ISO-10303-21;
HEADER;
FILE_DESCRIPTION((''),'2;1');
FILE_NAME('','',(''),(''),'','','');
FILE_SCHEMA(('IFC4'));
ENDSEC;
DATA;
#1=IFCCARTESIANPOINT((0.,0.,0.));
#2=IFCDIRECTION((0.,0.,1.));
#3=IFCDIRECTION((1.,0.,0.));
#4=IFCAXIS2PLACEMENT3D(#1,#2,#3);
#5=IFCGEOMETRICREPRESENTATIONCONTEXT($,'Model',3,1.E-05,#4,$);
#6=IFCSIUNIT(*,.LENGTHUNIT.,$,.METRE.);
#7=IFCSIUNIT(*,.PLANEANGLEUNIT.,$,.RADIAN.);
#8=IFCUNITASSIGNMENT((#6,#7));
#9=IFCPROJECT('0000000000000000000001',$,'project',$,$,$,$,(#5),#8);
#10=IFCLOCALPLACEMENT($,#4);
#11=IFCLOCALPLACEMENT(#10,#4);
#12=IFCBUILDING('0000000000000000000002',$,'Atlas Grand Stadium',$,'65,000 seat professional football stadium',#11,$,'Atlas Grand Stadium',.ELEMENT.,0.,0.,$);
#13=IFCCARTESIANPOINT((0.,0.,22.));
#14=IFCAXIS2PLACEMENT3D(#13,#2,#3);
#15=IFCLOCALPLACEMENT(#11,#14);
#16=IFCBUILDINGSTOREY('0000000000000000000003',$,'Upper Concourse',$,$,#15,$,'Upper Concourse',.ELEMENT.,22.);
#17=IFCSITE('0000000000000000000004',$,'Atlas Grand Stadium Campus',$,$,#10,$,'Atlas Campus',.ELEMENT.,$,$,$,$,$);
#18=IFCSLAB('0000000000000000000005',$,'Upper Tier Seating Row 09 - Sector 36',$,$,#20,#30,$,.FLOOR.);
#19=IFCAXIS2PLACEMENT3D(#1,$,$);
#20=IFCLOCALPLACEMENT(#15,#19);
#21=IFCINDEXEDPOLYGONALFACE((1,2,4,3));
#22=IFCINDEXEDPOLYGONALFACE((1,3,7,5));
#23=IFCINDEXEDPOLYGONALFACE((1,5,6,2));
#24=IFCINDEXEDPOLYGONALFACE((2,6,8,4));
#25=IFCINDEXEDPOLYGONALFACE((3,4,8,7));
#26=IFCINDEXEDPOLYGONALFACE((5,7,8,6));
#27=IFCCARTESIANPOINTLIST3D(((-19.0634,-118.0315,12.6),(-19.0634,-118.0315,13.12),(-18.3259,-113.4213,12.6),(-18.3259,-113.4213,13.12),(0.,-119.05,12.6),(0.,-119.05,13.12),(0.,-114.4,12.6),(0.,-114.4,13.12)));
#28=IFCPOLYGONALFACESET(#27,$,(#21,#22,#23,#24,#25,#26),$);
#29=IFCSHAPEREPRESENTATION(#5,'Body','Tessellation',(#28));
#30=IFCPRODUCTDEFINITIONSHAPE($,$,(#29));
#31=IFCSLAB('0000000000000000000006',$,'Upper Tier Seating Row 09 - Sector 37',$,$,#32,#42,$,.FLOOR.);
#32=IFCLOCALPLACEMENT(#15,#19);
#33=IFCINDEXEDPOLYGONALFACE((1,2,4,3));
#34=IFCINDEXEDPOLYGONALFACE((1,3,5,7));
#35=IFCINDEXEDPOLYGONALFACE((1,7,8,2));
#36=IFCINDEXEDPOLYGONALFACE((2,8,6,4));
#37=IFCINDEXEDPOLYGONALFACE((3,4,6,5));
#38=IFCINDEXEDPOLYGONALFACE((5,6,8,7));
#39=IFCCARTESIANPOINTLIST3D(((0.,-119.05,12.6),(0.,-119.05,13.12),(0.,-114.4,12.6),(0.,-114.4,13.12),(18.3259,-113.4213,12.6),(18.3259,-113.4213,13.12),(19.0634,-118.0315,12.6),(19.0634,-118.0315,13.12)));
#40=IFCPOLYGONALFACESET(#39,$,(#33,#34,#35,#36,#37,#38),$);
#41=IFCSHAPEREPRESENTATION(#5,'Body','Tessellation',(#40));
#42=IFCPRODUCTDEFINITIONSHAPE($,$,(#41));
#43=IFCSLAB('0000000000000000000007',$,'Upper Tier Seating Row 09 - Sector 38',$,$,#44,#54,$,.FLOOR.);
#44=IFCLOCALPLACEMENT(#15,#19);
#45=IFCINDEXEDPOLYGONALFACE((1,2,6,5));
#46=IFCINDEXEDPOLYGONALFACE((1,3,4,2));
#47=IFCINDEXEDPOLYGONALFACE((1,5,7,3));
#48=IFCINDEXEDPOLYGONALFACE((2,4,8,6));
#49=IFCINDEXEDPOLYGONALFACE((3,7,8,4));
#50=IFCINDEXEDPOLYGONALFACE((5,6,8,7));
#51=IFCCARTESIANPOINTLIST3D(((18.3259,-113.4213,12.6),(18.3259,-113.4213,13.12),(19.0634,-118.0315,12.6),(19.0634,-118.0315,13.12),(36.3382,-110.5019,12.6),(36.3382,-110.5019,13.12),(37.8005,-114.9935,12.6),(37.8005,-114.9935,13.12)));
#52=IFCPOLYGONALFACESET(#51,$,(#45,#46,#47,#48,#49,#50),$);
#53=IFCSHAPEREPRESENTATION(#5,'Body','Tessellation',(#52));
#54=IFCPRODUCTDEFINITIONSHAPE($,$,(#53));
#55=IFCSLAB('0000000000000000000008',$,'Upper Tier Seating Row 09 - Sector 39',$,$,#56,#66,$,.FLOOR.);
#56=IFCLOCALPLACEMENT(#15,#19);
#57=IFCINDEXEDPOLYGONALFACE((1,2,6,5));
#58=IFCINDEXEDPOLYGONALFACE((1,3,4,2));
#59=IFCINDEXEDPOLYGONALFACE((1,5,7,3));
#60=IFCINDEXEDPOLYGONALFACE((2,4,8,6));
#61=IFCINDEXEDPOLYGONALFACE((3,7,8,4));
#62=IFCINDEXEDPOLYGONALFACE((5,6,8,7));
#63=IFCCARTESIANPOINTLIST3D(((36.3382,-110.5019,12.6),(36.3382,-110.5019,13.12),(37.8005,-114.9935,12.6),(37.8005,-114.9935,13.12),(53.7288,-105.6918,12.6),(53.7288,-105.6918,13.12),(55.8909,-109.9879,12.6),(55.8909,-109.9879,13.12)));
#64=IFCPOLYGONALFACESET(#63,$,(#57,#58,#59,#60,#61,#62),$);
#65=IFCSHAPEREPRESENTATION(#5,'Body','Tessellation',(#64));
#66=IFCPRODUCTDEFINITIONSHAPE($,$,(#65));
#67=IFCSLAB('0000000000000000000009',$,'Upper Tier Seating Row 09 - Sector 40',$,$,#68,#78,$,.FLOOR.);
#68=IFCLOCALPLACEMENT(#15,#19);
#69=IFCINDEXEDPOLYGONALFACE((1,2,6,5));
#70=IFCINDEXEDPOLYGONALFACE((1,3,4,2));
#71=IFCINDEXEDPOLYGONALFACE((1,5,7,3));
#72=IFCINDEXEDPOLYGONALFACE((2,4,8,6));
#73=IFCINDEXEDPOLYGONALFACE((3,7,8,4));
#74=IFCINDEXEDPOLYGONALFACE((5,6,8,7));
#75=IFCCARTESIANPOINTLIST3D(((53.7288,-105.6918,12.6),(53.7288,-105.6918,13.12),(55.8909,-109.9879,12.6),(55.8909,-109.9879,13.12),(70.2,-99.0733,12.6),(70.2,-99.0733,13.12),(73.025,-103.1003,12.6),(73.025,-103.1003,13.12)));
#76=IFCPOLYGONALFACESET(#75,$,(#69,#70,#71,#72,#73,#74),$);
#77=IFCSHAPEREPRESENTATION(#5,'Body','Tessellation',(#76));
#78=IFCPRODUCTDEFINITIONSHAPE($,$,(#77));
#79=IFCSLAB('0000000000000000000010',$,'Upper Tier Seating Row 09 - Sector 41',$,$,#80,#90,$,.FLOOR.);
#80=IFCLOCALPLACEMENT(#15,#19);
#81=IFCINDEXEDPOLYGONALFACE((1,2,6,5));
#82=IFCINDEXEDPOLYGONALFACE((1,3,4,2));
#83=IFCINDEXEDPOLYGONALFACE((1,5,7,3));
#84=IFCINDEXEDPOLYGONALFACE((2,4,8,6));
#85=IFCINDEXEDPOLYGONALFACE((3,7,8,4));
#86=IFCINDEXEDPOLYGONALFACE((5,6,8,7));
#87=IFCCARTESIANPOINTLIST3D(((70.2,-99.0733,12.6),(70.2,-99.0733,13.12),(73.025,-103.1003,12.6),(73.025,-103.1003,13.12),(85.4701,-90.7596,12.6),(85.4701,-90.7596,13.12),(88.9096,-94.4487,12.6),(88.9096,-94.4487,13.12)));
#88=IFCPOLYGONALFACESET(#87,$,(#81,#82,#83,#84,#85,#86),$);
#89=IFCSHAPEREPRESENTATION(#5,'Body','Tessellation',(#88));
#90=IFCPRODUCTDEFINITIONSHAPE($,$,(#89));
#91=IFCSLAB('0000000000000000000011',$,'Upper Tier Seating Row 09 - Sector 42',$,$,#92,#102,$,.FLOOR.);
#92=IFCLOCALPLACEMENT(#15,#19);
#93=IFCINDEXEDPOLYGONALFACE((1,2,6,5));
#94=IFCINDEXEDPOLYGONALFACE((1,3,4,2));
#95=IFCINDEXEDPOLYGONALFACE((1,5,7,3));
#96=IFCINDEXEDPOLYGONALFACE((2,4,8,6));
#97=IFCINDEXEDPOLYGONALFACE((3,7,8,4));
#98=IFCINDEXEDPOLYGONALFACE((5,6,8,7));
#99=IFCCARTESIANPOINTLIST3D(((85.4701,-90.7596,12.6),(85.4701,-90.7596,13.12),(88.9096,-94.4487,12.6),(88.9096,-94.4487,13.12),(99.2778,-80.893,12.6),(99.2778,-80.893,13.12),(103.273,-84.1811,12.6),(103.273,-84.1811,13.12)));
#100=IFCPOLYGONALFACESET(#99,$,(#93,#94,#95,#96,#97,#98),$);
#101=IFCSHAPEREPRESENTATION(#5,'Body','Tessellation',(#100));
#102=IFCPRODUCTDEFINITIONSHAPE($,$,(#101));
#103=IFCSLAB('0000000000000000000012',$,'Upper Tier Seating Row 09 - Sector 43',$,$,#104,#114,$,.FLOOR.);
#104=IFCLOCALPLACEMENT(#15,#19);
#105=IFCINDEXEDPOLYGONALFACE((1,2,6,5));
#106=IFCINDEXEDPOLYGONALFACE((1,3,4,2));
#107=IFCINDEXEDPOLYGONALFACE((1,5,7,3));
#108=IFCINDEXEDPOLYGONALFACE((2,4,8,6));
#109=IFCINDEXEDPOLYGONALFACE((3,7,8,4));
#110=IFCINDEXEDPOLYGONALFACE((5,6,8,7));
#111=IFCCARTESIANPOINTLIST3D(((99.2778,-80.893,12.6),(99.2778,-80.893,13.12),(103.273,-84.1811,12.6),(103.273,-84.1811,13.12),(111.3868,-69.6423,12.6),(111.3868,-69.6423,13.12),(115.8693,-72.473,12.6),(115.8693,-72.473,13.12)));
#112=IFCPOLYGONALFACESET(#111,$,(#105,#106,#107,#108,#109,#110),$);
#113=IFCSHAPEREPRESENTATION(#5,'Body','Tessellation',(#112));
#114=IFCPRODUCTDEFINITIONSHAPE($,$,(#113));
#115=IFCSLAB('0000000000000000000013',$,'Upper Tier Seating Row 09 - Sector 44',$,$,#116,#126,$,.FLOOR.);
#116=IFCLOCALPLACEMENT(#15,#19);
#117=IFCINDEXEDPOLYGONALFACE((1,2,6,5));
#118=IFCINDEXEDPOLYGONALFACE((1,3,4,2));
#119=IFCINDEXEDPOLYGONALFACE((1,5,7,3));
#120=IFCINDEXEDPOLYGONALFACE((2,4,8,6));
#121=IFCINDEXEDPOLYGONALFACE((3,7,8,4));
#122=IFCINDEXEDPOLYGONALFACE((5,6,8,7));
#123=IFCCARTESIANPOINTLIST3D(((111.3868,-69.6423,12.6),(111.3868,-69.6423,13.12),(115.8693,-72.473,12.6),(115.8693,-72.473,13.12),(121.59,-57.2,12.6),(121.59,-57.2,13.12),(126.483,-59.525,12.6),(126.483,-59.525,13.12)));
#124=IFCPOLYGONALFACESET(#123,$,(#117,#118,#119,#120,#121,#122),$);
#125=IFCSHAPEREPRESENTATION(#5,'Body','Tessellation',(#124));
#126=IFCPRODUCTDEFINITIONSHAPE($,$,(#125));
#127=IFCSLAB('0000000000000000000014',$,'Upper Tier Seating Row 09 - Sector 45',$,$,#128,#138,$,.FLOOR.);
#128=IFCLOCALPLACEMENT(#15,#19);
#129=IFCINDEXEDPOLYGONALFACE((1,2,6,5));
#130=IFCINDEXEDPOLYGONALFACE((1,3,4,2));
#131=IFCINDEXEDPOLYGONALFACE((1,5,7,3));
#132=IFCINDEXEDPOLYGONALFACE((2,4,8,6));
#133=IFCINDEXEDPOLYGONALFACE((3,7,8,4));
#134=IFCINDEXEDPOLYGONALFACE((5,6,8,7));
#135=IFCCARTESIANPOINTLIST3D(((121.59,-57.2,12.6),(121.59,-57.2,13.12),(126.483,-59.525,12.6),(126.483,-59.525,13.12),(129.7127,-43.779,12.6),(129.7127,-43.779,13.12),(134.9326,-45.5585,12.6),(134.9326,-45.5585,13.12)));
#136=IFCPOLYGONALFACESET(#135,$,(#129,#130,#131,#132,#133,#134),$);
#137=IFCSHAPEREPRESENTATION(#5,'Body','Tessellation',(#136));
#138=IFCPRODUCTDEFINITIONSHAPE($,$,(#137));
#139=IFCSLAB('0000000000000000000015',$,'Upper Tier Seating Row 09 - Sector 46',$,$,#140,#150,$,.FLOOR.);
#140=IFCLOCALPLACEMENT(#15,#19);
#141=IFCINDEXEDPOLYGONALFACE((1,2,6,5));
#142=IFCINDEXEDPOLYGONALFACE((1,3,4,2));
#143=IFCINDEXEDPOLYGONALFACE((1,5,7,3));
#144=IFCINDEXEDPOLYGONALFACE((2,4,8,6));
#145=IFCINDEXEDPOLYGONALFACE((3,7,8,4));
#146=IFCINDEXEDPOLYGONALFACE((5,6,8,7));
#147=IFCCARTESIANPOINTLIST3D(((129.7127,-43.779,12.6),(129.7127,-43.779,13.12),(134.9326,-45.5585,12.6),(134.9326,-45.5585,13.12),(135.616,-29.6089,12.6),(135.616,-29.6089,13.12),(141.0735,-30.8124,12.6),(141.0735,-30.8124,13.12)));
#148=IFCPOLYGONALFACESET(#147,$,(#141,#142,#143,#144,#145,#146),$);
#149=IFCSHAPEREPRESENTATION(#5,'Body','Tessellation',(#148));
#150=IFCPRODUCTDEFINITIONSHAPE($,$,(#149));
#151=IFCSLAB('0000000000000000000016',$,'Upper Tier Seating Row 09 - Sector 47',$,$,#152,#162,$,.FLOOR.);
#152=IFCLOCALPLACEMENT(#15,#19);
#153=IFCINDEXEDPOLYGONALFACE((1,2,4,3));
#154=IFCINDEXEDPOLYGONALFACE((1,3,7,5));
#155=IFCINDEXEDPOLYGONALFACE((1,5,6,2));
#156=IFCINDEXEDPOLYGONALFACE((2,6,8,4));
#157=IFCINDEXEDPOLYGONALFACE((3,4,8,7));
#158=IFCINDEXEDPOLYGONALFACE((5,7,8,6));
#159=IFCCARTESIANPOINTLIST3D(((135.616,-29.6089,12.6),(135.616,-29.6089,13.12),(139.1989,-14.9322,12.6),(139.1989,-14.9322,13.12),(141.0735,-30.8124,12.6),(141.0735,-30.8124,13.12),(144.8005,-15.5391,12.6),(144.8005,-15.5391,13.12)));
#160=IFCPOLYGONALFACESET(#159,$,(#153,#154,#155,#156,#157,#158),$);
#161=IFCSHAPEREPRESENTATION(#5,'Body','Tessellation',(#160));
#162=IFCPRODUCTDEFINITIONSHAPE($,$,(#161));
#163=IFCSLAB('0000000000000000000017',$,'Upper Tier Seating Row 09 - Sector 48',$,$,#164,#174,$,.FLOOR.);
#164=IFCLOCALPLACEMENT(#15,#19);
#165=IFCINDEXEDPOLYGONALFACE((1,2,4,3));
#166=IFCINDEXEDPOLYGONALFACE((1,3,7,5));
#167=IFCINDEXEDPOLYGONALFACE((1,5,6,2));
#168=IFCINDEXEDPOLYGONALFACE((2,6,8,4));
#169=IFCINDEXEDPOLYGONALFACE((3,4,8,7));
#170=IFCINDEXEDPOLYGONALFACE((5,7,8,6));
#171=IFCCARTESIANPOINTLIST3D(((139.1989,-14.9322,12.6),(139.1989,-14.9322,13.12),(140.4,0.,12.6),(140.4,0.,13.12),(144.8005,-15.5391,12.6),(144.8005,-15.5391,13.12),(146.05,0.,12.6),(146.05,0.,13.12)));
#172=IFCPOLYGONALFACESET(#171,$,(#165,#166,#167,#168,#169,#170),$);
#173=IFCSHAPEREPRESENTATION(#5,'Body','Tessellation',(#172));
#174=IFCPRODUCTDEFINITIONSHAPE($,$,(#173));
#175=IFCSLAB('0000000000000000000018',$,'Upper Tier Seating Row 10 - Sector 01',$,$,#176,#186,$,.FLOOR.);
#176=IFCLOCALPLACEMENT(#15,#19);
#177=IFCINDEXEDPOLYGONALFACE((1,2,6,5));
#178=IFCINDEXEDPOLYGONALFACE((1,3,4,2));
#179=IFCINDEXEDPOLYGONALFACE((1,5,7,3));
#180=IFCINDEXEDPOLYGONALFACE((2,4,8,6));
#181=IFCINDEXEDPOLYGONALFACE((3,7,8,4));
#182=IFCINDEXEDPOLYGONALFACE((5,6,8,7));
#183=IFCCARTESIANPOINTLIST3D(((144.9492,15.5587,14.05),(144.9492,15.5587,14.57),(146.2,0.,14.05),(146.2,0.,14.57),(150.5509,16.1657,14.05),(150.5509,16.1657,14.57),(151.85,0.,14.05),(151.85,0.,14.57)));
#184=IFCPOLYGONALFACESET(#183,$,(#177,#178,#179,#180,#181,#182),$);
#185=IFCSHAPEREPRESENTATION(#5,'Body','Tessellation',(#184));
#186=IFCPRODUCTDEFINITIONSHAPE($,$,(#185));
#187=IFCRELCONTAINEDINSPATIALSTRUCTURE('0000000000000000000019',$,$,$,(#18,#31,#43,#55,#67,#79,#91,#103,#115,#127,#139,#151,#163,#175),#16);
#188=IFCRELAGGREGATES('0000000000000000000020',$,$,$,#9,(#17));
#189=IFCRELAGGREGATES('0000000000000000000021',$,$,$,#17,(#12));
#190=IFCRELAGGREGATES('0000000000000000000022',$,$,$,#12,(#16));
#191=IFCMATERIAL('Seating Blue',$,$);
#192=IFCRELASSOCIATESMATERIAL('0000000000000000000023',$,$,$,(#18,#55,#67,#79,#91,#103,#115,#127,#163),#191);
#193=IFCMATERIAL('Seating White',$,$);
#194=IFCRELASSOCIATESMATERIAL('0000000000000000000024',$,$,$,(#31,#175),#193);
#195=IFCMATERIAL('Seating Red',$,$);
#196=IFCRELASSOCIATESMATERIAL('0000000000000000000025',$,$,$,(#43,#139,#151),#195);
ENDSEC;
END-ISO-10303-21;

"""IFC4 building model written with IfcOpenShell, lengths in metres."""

from ifc_helpers import new_model, si_unit, frame, origin_with_axes, place, context, project, spatial, polyline, outline, extrude, material, element, save


model = new_model("IFC4")

# Units and contexts
model_context = context("Model", 3, precision=1e-05, world=origin_with_axes())
ifc_project = project(units=[si_unit("LENGTHUNIT", "METRE"), si_unit("PLANEANGLEUNIT", "RADIAN")], contexts=[model_context])

# Site, building, storey
site_placement = place(None, origin_with_axes())
site = spatial("IfcSite", under=ifc_project, at=site_placement, Name="Atlas Grand Stadium Campus", LongName="Atlas Campus", CompositionType="ELEMENT")
building_placement = place(site_placement, origin_with_axes())
building = spatial("IfcBuilding", under=site, at=building_placement, Name="Atlas Grand Stadium", ObjectType="65,000 seat professional football stadium", LongName="Atlas Grand Stadium", CompositionType="ELEMENT", ElevationOfRefHeight=0.0, ElevationOfTerrain=0.0)
storey_placement = place(building_placement, frame((0.0, 0.0, 22.0), z_axis=(0.0, 0.0, 1.0), x_axis=(1.0, 0.0, 0.0)))
storey = spatial("IfcBuildingStorey", under=building, at=storey_placement, Name="Upper Concourse", LongName="Upper Concourse", CompositionType="ELEMENT", Elevation=22.0)

# Slabs
ifc_material_1 = material(Name="Seating Blue")
slab_1_placement = place(storey_placement, frame((0.0, 0.0, 12.6), z_axis=(0.0, 0.0, 1.0), x_axis=(1.0, 0.0, 0.0)))
element("IfcSlab", 1, at=slab_1_placement, inside=storey, material=ifc_material_1, Name="Upper Tier Seating Row 09 - Sector 36", PredefinedType="FLOOR", context=model_context, shape_type="SweptSolid", body=[
    extrude(outline(polyline([(-19.0633, -118.0315), (0.0, -119.05), (0.0, -114.4), (-18.3259, -113.4213), (-19.0633, -118.0315)])), origin_with_axes(), (0.0, 0.0, 1.0), 0.52),
])
ifc_material_2 = material(Name="Seating White")
slab_2_placement = place(storey_placement, frame((0.0, 0.0, 12.6), z_axis=(0.0, 0.0, 1.0), x_axis=(1.0, 0.0, 0.0)))
element("IfcSlab", 2, at=slab_2_placement, inside=storey, material=ifc_material_2, Name="Upper Tier Seating Row 09 - Sector 37", PredefinedType="FLOOR", context=model_context, shape_type="SweptSolid", body=[
    extrude(outline(polyline([(0.0, -119.05), (19.0633, -118.0315), (18.3259, -113.4213), (0.0, -114.4), (0.0, -119.05)])), origin_with_axes(), (0.0, 0.0, 1.0), 0.52),
])
ifc_material_3 = material(Name="Seating Red")
slab_3_placement = place(storey_placement, frame((0.0, 0.0, 12.6), z_axis=(0.0, 0.0, 1.0), x_axis=(1.0, 0.0, 0.0)))
element("IfcSlab", 3, at=slab_3_placement, inside=storey, material=ifc_material_3, Name="Upper Tier Seating Row 09 - Sector 38", PredefinedType="FLOOR", context=model_context, shape_type="SweptSolid", body=[
    extrude(outline(polyline([(19.0633, -118.0315), (37.8005, -114.9935), (36.3382, -110.5019), (18.3259, -113.4213), (19.0633, -118.0315)])), origin_with_axes(), (0.0, 0.0, 1.0), 0.52),
])
slab_4_placement = place(storey_placement, frame((0.0, 0.0, 12.6), z_axis=(0.0, 0.0, 1.0), x_axis=(1.0, 0.0, 0.0)))
element("IfcSlab", 4, at=slab_4_placement, inside=storey, material=ifc_material_1, Name="Upper Tier Seating Row 09 - Sector 39", PredefinedType="FLOOR", context=model_context, shape_type="SweptSolid", body=[
    extrude(outline(polyline([(37.8005, -114.9935), (55.8909, -109.9879), (53.7287, -105.6918), (36.3382, -110.5019), (37.8005, -114.9935)])), origin_with_axes(), (0.0, 0.0, 1.0), 0.52),
])
slab_5_placement = place(storey_placement, frame((0.0, 0.0, 12.6), z_axis=(0.0, 0.0, 1.0), x_axis=(1.0, 0.0, 0.0)))
element("IfcSlab", 5, at=slab_5_placement, inside=storey, material=ifc_material_1, Name="Upper Tier Seating Row 09 - Sector 40", PredefinedType="FLOOR", context=model_context, shape_type="SweptSolid", body=[
    extrude(outline(polyline([(55.8909, -109.9879), (73.025, -103.1003), (70.2, -99.0733), (53.7287, -105.6918), (55.8909, -109.9879)])), origin_with_axes(), (0.0, 0.0, 1.0), 0.52),
])
slab_6_placement = place(storey_placement, frame((0.0, 0.0, 12.6), z_axis=(0.0, 0.0, 1.0), x_axis=(1.0, 0.0, 0.0)))
element("IfcSlab", 6, at=slab_6_placement, inside=storey, material=ifc_material_1, Name="Upper Tier Seating Row 09 - Sector 41", PredefinedType="FLOOR", context=model_context, shape_type="SweptSolid", body=[
    extrude(outline(polyline([(73.025, -103.1003), (88.9096, -94.4487), (85.4701, -90.7596), (70.2, -99.0733), (73.025, -103.1003)])), origin_with_axes(), (0.0, 0.0, 1.0), 0.52),
])
slab_7_placement = place(storey_placement, frame((0.0, 0.0, 12.6), z_axis=(0.0, 0.0, 1.0), x_axis=(1.0, 0.0, 0.0)))
element("IfcSlab", 7, at=slab_7_placement, inside=storey, material=ifc_material_1, Name="Upper Tier Seating Row 09 - Sector 42", PredefinedType="FLOOR", context=model_context, shape_type="SweptSolid", body=[
    extrude(outline(polyline([(88.9096, -94.4487), (103.2729, -84.1811), (99.2778, -80.893), (85.4701, -90.7596), (88.9096, -94.4487)])), origin_with_axes(), (0.0, 0.0, 1.0), 0.52),
])
slab_8_placement = place(storey_placement, frame((0.0, 0.0, 12.6), z_axis=(0.0, 0.0, 1.0), x_axis=(1.0, 0.0, 0.0)))
element("IfcSlab", 8, at=slab_8_placement, inside=storey, material=ifc_material_1, Name="Upper Tier Seating Row 09 - Sector 43", PredefinedType="FLOOR", context=model_context, shape_type="SweptSolid", body=[
    extrude(outline(polyline([(103.2729, -84.1811), (115.8693, -72.4731), (111.3868, -69.6423), (99.2778, -80.893), (103.2729, -84.1811)])), origin_with_axes(), (0.0, 0.0, 1.0), 0.52),
])
slab_9_placement = place(storey_placement, frame((0.0, 0.0, 12.6), z_axis=(0.0, 0.0, 1.0), x_axis=(1.0, 0.0, 0.0)))
element("IfcSlab", 9, at=slab_9_placement, inside=storey, material=ifc_material_1, Name="Upper Tier Seating Row 09 - Sector 44", PredefinedType="FLOOR", context=model_context, shape_type="SweptSolid", body=[
    extrude(outline(polyline([(115.8693, -72.4731), (126.483, -59.525), (121.59, -57.2), (111.3868, -69.6423), (115.8693, -72.4731)])), origin_with_axes(), (0.0, 0.0, 1.0), 0.52),
])
slab_10_placement = place(storey_placement, frame((0.0, 0.0, 12.6), z_axis=(0.0, 0.0, 1.0), x_axis=(1.0, 0.0, 0.0)))
element("IfcSlab", 10, at=slab_10_placement, inside=storey, material=ifc_material_1, Name="Upper Tier Seating Row 09 - Sector 45", PredefinedType="FLOOR", context=model_context, shape_type="SweptSolid", body=[
    extrude(outline(polyline([(126.483, -59.525), (134.9326, -45.5585), (129.7127, -43.779), (121.59, -57.2), (126.483, -59.525)])), origin_with_axes(), (0.0, 0.0, 1.0), 0.52),
])
slab_11_placement = place(storey_placement, frame((0.0, 0.0, 12.6), z_axis=(0.0, 0.0, 1.0), x_axis=(1.0, 0.0, 0.0)))
element("IfcSlab", 11, at=slab_11_placement, inside=storey, material=ifc_material_3, Name="Upper Tier Seating Row 09 - Sector 46", PredefinedType="FLOOR", context=model_context, shape_type="SweptSolid", body=[
    extrude(outline(polyline([(134.9326, -45.5585), (141.0735, -30.8124), (135.616, -29.6089), (129.7127, -43.779), (134.9326, -45.5585)])), origin_with_axes(), (0.0, 0.0, 1.0), 0.52),
])
slab_12_placement = place(storey_placement, frame((0.0, 0.0, 12.6), z_axis=(0.0, 0.0, 1.0), x_axis=(1.0, 0.0, 0.0)))
element("IfcSlab", 12, at=slab_12_placement, inside=storey, material=ifc_material_3, Name="Upper Tier Seating Row 09 - Sector 47", PredefinedType="FLOOR", context=model_context, shape_type="SweptSolid", body=[
    extrude(outline(polyline([(141.0735, -30.8124), (144.8005, -15.5391), (139.1989, -14.9322), (135.616, -29.6089), (141.0735, -30.8124)])), origin_with_axes(), (0.0, 0.0, 1.0), 0.52),
])
slab_13_placement = place(storey_placement, frame((0.0, 0.0, 12.6), z_axis=(0.0, 0.0, 1.0), x_axis=(1.0, 0.0, 0.0)))
element("IfcSlab", 13, at=slab_13_placement, inside=storey, material=ifc_material_1, Name="Upper Tier Seating Row 09 - Sector 48", PredefinedType="FLOOR", context=model_context, shape_type="SweptSolid", body=[
    extrude(outline(polyline([(144.8005, -15.5391), (146.05, 0.0), (140.4, 0.0), (139.1989, -14.9322), (144.8005, -15.5391)])), origin_with_axes(), (0.0, 0.0, 1.0), 0.52),
])
slab_14_placement = place(storey_placement, frame((0.0, 0.0, 14.05), z_axis=(0.0, 0.0, 1.0), x_axis=(1.0, 0.0, 0.0)))
element("IfcSlab", 14, at=slab_14_placement, inside=storey, material=ifc_material_2, Name="Upper Tier Seating Row 10 - Sector 01", PredefinedType="FLOOR", context=model_context, shape_type="SweptSolid", body=[
    extrude(outline(polyline([(151.85, 0.0), (150.5509, 16.1657), (144.9492, 15.5587), (146.2, 0.0), (151.85, 0.0)])), origin_with_axes(), (0.0, 0.0, 1.0), 0.52),
])

save(model, "model.ifc")
